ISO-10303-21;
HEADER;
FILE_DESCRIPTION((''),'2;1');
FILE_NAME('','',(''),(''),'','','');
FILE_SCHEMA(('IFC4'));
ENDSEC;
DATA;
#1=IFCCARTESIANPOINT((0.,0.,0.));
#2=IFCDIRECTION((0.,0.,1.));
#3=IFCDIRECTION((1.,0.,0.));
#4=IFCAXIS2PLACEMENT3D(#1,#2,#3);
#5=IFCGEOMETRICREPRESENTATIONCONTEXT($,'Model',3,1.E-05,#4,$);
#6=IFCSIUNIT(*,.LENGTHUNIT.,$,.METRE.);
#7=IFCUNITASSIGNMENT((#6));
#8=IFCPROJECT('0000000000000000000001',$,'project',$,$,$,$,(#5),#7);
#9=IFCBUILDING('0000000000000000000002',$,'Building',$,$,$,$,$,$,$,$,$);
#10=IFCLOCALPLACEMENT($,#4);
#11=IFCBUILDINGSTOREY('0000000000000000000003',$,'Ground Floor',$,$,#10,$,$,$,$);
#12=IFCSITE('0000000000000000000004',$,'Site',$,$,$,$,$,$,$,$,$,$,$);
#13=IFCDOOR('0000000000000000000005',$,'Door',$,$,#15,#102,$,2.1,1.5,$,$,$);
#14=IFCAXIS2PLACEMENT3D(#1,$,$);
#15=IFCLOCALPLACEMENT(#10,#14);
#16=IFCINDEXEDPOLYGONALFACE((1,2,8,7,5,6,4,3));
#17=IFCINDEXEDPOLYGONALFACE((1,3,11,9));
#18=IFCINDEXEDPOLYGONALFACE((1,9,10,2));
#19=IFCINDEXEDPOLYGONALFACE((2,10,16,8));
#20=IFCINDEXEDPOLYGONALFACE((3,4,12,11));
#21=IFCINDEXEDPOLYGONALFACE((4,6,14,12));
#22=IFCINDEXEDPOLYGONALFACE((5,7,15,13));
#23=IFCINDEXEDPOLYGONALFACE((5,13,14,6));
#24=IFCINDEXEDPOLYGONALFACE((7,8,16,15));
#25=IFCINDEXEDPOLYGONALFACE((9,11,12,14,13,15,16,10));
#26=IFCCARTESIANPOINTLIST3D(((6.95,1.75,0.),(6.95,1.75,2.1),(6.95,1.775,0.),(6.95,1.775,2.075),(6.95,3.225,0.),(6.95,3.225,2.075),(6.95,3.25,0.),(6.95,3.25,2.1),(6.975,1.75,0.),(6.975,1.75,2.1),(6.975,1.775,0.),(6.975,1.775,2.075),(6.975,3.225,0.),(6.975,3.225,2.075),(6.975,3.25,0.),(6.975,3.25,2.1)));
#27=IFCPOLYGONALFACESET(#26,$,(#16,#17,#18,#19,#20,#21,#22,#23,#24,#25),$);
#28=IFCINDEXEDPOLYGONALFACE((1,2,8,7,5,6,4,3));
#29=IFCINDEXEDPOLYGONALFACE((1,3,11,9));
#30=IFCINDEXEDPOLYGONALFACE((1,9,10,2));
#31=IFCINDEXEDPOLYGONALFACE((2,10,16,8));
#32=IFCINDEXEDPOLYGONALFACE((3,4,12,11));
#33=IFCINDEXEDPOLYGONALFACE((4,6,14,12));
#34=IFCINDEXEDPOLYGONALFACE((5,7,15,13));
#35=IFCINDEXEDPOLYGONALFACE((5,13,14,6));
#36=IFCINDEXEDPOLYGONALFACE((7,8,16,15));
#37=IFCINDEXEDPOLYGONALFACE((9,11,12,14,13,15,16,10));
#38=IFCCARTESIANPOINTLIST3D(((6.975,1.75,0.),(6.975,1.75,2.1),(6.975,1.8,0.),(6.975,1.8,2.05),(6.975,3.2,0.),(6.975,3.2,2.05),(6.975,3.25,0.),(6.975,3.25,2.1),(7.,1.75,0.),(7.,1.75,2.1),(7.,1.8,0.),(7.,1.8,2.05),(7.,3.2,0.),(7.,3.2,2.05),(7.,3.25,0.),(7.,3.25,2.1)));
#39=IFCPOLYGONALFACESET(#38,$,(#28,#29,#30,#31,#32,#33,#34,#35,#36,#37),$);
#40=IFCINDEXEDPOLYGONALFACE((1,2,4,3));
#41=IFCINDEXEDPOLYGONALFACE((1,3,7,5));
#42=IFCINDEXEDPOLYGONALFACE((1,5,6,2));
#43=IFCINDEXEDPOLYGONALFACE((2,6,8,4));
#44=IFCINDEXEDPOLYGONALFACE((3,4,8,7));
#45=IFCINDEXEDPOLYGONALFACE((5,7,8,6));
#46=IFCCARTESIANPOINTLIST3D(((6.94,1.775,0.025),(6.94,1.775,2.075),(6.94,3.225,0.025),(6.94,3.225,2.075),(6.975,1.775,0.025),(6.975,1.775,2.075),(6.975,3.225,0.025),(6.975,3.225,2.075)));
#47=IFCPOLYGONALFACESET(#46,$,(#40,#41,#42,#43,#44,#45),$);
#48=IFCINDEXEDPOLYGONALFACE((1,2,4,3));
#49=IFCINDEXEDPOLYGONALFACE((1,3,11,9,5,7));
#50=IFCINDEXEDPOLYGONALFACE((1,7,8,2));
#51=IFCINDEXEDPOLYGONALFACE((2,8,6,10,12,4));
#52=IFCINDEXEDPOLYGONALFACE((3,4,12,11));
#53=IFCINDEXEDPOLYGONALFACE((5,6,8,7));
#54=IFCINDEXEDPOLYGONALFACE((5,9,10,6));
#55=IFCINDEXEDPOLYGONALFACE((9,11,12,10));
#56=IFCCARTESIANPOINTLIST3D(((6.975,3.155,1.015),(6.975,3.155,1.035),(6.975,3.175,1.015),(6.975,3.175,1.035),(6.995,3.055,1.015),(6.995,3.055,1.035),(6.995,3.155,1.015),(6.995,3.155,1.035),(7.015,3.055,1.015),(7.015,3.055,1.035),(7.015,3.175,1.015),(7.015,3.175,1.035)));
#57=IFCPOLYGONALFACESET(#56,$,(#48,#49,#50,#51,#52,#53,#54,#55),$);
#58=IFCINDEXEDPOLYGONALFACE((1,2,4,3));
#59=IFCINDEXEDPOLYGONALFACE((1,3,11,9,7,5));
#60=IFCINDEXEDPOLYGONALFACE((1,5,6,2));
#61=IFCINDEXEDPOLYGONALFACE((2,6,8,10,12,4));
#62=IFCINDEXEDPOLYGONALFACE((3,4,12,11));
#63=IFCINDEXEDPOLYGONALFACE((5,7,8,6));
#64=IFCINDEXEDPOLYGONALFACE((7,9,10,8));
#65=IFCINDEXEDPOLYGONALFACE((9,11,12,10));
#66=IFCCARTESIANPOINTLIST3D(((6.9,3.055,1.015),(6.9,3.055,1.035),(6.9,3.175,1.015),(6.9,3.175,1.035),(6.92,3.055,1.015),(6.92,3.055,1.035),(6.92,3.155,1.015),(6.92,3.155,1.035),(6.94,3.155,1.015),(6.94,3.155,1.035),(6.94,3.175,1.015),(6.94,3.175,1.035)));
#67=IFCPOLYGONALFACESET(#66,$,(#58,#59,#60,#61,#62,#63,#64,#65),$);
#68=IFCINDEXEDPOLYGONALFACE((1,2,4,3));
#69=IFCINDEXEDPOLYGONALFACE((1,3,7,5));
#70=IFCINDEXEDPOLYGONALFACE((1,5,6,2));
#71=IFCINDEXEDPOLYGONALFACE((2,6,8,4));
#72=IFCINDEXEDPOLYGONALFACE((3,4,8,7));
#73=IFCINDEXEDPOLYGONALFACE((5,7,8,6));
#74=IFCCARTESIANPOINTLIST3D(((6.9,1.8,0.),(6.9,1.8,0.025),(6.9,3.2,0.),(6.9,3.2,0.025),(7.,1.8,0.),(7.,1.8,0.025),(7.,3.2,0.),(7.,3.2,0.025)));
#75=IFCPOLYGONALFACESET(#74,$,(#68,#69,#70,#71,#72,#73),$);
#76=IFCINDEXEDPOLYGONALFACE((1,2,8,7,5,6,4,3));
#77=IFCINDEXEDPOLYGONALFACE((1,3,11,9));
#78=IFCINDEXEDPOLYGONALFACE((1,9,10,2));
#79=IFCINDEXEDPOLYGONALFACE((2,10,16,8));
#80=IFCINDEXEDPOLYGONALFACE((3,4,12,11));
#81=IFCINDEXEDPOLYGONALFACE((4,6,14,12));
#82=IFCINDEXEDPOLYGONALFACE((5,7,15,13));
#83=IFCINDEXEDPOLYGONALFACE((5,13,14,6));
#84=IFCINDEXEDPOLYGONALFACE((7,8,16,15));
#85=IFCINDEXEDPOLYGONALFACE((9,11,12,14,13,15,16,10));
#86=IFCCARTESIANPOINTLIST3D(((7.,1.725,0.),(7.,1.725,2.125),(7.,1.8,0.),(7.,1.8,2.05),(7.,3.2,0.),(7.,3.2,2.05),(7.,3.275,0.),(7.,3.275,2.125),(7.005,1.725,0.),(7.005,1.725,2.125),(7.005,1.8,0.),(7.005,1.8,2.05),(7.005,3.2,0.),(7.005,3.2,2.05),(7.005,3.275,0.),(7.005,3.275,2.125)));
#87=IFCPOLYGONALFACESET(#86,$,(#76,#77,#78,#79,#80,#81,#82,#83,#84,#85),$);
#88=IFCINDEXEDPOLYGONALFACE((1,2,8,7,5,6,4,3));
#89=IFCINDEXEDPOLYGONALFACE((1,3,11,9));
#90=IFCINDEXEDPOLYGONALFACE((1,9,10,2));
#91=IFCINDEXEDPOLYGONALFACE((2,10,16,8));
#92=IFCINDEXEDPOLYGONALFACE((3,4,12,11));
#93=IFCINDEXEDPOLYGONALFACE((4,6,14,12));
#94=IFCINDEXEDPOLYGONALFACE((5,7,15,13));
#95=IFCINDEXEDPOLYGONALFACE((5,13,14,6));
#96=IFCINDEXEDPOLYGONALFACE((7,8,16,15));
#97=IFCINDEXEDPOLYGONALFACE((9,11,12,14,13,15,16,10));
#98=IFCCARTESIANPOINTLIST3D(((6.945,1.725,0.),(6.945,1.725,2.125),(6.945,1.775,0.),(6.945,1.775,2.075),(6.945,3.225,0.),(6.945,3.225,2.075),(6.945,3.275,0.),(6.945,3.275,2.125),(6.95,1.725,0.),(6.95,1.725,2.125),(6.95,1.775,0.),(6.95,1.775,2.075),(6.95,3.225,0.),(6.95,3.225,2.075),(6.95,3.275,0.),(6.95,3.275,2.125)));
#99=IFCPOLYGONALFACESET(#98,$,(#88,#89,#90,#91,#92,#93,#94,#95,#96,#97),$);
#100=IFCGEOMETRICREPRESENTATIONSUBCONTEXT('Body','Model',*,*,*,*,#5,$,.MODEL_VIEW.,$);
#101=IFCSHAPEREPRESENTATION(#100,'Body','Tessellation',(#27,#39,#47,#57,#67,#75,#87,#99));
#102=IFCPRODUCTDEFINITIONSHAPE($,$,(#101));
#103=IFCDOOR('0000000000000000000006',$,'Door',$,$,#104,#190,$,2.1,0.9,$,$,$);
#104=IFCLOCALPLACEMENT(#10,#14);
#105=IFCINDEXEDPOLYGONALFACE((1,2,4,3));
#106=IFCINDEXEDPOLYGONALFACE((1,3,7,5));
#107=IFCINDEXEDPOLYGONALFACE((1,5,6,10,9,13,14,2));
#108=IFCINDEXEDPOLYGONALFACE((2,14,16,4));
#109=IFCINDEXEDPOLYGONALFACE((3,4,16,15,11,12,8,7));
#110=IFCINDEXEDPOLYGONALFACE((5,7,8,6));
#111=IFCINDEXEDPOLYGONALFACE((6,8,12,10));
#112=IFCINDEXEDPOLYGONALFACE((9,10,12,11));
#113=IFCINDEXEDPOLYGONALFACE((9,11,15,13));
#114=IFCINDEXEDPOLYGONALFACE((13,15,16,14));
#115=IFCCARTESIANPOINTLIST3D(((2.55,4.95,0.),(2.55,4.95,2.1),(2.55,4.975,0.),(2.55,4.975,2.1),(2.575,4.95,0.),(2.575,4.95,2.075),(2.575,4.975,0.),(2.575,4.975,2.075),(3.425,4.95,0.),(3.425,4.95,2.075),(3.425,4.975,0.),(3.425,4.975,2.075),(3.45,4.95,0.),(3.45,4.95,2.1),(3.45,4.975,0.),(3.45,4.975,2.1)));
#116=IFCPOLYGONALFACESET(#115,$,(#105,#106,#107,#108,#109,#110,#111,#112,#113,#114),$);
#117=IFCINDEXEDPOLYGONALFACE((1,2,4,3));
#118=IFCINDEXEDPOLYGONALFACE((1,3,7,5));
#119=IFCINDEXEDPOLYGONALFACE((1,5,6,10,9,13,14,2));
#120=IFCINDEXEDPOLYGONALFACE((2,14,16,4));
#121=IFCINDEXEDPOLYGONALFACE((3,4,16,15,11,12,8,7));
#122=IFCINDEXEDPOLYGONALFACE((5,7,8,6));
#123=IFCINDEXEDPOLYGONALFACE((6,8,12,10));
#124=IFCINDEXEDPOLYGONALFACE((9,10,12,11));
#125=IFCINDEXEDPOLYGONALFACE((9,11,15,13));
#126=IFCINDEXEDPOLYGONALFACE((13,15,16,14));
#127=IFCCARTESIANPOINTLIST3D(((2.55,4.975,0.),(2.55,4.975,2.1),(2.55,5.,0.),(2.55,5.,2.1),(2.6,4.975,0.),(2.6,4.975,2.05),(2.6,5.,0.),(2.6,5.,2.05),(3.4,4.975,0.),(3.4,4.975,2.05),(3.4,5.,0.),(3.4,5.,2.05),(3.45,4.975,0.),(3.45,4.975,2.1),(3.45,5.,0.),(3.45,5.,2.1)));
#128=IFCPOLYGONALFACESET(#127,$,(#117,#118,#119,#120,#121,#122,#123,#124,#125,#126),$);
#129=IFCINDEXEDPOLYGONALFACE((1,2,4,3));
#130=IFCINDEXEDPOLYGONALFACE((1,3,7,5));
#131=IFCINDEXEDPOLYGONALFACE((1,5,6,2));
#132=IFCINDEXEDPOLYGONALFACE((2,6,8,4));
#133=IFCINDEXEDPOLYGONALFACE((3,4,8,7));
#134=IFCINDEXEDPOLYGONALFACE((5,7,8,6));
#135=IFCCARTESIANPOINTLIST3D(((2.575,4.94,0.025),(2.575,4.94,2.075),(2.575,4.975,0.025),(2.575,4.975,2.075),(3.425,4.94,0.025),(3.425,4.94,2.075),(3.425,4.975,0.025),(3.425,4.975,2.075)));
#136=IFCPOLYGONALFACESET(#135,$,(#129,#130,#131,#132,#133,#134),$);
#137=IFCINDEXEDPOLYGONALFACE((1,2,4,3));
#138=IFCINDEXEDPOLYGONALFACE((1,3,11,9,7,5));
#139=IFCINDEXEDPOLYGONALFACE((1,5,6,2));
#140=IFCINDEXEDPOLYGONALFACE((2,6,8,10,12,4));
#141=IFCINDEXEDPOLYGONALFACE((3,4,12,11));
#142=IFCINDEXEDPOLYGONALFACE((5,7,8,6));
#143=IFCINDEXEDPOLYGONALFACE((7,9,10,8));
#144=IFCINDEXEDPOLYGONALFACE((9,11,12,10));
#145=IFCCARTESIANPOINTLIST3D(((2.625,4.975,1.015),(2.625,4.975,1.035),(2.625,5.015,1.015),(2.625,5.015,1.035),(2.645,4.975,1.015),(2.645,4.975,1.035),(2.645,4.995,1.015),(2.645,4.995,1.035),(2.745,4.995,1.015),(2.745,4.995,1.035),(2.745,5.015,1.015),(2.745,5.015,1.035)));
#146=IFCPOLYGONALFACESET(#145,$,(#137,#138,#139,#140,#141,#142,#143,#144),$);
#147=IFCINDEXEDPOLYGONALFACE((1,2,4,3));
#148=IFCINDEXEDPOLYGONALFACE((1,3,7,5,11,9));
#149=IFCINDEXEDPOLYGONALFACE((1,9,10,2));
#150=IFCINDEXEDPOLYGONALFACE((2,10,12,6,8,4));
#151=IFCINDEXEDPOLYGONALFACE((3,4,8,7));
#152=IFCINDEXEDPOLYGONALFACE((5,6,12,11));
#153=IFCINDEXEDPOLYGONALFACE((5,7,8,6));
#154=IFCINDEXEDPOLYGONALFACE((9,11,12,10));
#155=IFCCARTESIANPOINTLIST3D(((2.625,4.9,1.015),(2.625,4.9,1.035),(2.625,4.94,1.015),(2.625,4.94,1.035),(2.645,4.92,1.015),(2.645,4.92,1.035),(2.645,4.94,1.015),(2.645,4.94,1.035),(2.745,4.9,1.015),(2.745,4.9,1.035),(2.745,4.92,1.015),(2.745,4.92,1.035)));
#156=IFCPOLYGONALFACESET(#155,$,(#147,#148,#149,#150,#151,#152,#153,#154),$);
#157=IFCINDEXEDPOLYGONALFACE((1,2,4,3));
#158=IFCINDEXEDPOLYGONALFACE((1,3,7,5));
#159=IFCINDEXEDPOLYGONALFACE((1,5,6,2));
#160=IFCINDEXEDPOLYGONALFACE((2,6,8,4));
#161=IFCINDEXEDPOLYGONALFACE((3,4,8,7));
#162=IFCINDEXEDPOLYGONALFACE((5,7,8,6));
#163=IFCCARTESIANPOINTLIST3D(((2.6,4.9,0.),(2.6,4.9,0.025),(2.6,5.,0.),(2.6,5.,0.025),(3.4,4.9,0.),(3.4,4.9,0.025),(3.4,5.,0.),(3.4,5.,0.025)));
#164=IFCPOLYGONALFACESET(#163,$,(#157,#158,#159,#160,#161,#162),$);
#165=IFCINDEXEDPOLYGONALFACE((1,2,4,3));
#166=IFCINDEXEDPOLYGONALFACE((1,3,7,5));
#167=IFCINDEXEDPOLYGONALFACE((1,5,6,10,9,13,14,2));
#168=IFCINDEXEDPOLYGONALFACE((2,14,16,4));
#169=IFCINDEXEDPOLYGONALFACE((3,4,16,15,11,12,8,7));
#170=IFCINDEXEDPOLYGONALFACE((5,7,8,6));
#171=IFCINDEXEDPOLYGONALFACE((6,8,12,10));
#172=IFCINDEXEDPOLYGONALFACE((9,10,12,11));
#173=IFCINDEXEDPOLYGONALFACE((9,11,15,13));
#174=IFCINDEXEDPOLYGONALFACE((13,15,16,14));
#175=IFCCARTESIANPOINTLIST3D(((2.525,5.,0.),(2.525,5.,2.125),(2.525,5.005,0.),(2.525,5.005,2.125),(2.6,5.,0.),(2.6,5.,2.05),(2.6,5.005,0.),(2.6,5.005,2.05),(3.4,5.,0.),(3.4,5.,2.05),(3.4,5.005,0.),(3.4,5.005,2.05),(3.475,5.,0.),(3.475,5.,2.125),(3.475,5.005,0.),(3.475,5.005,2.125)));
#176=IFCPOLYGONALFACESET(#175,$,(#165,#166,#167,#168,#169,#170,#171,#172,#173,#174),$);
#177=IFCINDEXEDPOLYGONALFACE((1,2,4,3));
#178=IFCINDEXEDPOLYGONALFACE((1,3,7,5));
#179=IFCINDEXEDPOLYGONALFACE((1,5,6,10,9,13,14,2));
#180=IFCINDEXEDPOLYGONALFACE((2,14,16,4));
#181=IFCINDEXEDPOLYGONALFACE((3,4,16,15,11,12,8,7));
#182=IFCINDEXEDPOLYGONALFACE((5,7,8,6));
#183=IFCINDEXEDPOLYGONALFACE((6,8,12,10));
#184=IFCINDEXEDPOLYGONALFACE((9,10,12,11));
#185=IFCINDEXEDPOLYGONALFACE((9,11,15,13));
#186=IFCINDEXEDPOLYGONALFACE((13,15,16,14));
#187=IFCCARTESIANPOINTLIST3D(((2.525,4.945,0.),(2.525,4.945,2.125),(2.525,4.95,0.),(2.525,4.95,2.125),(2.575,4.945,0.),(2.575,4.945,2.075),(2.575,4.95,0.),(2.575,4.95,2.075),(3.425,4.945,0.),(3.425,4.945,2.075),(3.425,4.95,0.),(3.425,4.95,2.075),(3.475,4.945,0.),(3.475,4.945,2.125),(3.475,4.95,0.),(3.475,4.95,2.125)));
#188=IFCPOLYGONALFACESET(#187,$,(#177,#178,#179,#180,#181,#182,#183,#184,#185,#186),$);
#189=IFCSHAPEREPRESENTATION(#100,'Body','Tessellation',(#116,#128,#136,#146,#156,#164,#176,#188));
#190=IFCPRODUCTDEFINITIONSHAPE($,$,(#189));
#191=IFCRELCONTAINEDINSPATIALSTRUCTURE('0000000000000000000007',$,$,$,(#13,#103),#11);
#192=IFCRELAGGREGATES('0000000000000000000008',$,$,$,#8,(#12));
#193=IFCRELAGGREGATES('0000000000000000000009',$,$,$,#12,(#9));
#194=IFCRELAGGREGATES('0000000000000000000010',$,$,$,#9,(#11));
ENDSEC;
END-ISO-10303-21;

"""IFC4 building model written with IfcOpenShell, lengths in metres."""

from ifc_helpers import new_model, si_unit, frame, origin_with_axes, place, context, subcontext, project, spatial, line, indexed_curve, outline, extrude, element, save


model = new_model("IFC4")

# Units and contexts
model_context = context("Model", 3, precision=1e-05, world=origin_with_axes())
body_context = subcontext(model_context, "Body", "Model", "MODEL_VIEW")
ifc_project = project(units=[si_unit("LENGTHUNIT", "METRE")], contexts=[model_context])

# Site, building, storey
site = spatial("IfcSite", under=ifc_project, Name="Site")
building = spatial("IfcBuilding", under=site, Name="Building")
storey_placement = place(None, origin_with_axes())
storey = spatial("IfcBuildingStorey", under=building, at=storey_placement, Name="Ground Floor")

# Doors
door_1_placement = place(storey_placement, frame((7.0, 1.75, 0.0), z_axis=(0.0, 0.0, 1.0), x_axis=(0.0, 1.0, 0.0)))
element("IfcDoor", 1, at=door_1_placement, inside=storey, Name="Door", OverallHeight=2.1, OverallWidth=1.5, context=body_context, shape_type="SweptSolid", body=[
    extrude(outline(indexed_curve([(0.0, 0.0), (0.0, 2.1), (1.5, 2.1), (1.5, 0.0), (1.475, 0.0), (1.475, 2.075), (0.025, 2.075), (0.025, 0.0)], segments=[line(1, 2, 3, 4, 5, 6, 7, 8, 1)])), frame((0.0, 0.025, 0.0), z_axis=(0.0, -1.0, 0.0), x_axis=(1.0, 0.0, 0.0)), (0.0, 0.0, -1.0), 0.025),
    extrude(outline(indexed_curve([(0.0, 0.0), (0.0, 2.1), (1.5, 2.1), (1.5, 0.0), (1.45, 0.0), (1.45, 2.05), (0.05, 2.05), (0.05, 0.0)], segments=[line(1, 2, 3, 4, 5, 6, 7, 8, 1)])), frame((0.0, 0.0, 0.0), z_axis=(0.0, -1.0, 0.0), x_axis=(1.0, 0.0, 0.0)), (0.0, 0.0, -1.0), 0.025),
    extrude(outline(indexed_curve([(0.0, 0.0), (1.45, 0.0), (1.45, 0.035), (0.0, 0.035)], segments=[line(1, 2, 3, 4, 1)])), frame((0.025, 0.025, 0.025), z_axis=(0.0, 0.0, 1.0), x_axis=(1.0, 0.0, 0.0)), (0.0, 0.0, 1.0), 2.05),
    extrude(outline(indexed_curve([(0.0, 0.0), (0.0, -0.04), (-0.12, -0.04), (-0.12, -0.02), (-0.02, -0.02), (-0.02, 0.0)], segments=[line(1, 2, 3, 4, 5, 6, 1)])), frame((1.425, 0.025, 1.015), z_axis=(0.0, 0.0, 1.0), x_axis=(1.0, 0.0, 0.0)), (0.0, 0.0, 1.0), 0.02),
    extrude(outline(indexed_curve([(0.0, 0.0), (0.0, 0.04), (-0.12, 0.04), (-0.12, 0.02), (-0.02, 0.02), (-0.02, 0.0)], segments=[line(1, 2, 3, 4, 5, 6, 1)])), frame((1.425, 0.06, 1.015), z_axis=(0.0, 0.0, 1.0), x_axis=(1.0, 0.0, 0.0)), (0.0, 0.0, 1.0), 0.02),
    extrude(outline(indexed_curve([(0.0, 0.0), (1.4, 0.0), (1.4, 0.1), (0.0, 0.1)], segments=[line(1, 2, 3, 4, 1)])), frame((0.05, 0.0, 0.0), z_axis=(0.0, 0.0, 1.0), x_axis=(1.0, 0.0, 0.0)), (0.0, 0.0, 1.0), 0.025),
    extrude(outline(indexed_curve([(0.0, 0.0), (0.0, 2.125), (1.55, 2.125), (1.55, 0.0), (1.475, 0.0), (1.475, 2.05), (0.075, 2.05), (0.075, 0.0)], segments=[line(1, 2, 3, 4, 5, 6, 7, 8, 1)])), frame((-0.025, -0.005, 0.0), z_axis=(0.0, -1.0, 0.0), x_axis=(1.0, 0.0, 0.0)), (0.0, 0.0, -1.0), 0.005),
    extrude(outline(indexed_curve([(0.0, 0.0), (0.0, 2.125), (1.55, 2.125), (1.55, 0.0), (1.5, 0.0), (1.5, 2.075), (0.05, 2.075), (0.05, 0.0)], segments=[line(1, 2, 3, 4, 5, 6, 7, 8, 1)])), frame((-0.025, 0.05, 0.0), z_axis=(0.0, -1.0, 0.0), x_axis=(1.0, 0.0, 0.0)), (0.0, 0.0, -1.0), 0.005),
])
door_2_placement = place(storey_placement, frame((3.45, 5.0, 0.0), z_axis=(0.0, 0.0, 1.0), x_axis=(-1.0, 0.0, 0.0)))
element("IfcDoor", 2, at=door_2_placement, inside=storey, Name="Door", OverallHeight=2.1, OverallWidth=0.9, context=body_context, shape_type="SweptSolid", body=[
    extrude(outline(indexed_curve([(0.0, 0.0), (0.0, 2.1), (0.9, 2.1), (0.9, 0.0), (0.875, 0.0), (0.875, 2.075), (0.025, 2.075), (0.025, 0.0)], segments=[line(1, 2, 3, 4, 5, 6, 7, 8, 1)])), frame((0.0, 0.025, 0.0), z_axis=(0.0, -1.0, 0.0), x_axis=(1.0, 0.0, 0.0)), (0.0, 0.0, -1.0), 0.025),
    extrude(outline(indexed_curve([(0.0, 0.0), (0.0, 2.1), (0.9, 2.1), (0.9, 0.0), (0.85, 0.0), (0.85, 2.05), (0.05, 2.05), (0.05, 0.0)], segments=[line(1, 2, 3, 4, 5, 6, 7, 8, 1)])), frame((0.0, 0.0, 0.0), z_axis=(0.0, -1.0, 0.0), x_axis=(1.0, 0.0, 0.0)), (0.0, 0.0, -1.0), 0.025),
    extrude(outline(indexed_curve([(0.0, 0.0), (0.85, 0.0), (0.85, 0.035), (0.0, 0.035)], segments=[line(1, 2, 3, 4, 1)])), frame((0.025, 0.025, 0.025), z_axis=(0.0, 0.0, 1.0), x_axis=(1.0, 0.0, 0.0)), (0.0, 0.0, 1.0), 2.05),
    extrude(outline(indexed_curve([(0.0, 0.0), (0.0, -0.04), (-0.12, -0.04), (-0.12, -0.02), (-0.02, -0.02), (-0.02, 0.0)], segments=[line(1, 2, 3, 4, 5, 6, 1)])), frame((0.825, 0.025, 1.015), z_axis=(0.0, 0.0, 1.0), x_axis=(1.0, 0.0, 0.0)), (0.0, 0.0, 1.0), 0.02),
    extrude(outline(indexed_curve([(0.0, 0.0), (0.0, 0.04), (-0.12, 0.04), (-0.12, 0.02), (-0.02, 0.02), (-0.02, 0.0)], segments=[line(1, 2, 3, 4, 5, 6, 1)])), frame((0.825, 0.06, 1.015), z_axis=(0.0, 0.0, 1.0), x_axis=(1.0, 0.0, 0.0)), (0.0, 0.0, 1.0), 0.02),
    extrude(outline(indexed_curve([(0.0, 0.0), (0.8, 0.0), (0.8, 0.1), (0.0, 0.1)], segments=[line(1, 2, 3, 4, 1)])), frame((0.05, 0.0, 0.0), z_axis=(0.0, 0.0, 1.0), x_axis=(1.0, 0.0, 0.0)), (0.0, 0.0, 1.0), 0.025),
    extrude(outline(indexed_curve([(0.0, 0.0), (0.0, 2.125), (0.95, 2.125), (0.95, 0.0), (0.875, 0.0), (0.875, 2.05), (0.075, 2.05), (0.075, 0.0)], segments=[line(1, 2, 3, 4, 5, 6, 7, 8, 1)])), frame((-0.025, -0.005, 0.0), z_axis=(0.0, -1.0, 0.0), x_axis=(1.0, 0.0, 0.0)), (0.0, 0.0, -1.0), 0.005),
    extrude(outline(indexed_curve([(0.0, 0.0), (0.0, 2.125), (0.95, 2.125), (0.95, 0.0), (0.9, 0.0), (0.9, 2.075), (0.05, 2.075), (0.05, 0.0)], segments=[line(1, 2, 3, 4, 5, 6, 7, 8, 1)])), frame((-0.025, 0.05, 0.0), z_axis=(0.0, -1.0, 0.0), x_axis=(1.0, 0.0, 0.0)), (0.0, 0.0, -1.0), 0.005),
])

save(model, "model.ifc")
